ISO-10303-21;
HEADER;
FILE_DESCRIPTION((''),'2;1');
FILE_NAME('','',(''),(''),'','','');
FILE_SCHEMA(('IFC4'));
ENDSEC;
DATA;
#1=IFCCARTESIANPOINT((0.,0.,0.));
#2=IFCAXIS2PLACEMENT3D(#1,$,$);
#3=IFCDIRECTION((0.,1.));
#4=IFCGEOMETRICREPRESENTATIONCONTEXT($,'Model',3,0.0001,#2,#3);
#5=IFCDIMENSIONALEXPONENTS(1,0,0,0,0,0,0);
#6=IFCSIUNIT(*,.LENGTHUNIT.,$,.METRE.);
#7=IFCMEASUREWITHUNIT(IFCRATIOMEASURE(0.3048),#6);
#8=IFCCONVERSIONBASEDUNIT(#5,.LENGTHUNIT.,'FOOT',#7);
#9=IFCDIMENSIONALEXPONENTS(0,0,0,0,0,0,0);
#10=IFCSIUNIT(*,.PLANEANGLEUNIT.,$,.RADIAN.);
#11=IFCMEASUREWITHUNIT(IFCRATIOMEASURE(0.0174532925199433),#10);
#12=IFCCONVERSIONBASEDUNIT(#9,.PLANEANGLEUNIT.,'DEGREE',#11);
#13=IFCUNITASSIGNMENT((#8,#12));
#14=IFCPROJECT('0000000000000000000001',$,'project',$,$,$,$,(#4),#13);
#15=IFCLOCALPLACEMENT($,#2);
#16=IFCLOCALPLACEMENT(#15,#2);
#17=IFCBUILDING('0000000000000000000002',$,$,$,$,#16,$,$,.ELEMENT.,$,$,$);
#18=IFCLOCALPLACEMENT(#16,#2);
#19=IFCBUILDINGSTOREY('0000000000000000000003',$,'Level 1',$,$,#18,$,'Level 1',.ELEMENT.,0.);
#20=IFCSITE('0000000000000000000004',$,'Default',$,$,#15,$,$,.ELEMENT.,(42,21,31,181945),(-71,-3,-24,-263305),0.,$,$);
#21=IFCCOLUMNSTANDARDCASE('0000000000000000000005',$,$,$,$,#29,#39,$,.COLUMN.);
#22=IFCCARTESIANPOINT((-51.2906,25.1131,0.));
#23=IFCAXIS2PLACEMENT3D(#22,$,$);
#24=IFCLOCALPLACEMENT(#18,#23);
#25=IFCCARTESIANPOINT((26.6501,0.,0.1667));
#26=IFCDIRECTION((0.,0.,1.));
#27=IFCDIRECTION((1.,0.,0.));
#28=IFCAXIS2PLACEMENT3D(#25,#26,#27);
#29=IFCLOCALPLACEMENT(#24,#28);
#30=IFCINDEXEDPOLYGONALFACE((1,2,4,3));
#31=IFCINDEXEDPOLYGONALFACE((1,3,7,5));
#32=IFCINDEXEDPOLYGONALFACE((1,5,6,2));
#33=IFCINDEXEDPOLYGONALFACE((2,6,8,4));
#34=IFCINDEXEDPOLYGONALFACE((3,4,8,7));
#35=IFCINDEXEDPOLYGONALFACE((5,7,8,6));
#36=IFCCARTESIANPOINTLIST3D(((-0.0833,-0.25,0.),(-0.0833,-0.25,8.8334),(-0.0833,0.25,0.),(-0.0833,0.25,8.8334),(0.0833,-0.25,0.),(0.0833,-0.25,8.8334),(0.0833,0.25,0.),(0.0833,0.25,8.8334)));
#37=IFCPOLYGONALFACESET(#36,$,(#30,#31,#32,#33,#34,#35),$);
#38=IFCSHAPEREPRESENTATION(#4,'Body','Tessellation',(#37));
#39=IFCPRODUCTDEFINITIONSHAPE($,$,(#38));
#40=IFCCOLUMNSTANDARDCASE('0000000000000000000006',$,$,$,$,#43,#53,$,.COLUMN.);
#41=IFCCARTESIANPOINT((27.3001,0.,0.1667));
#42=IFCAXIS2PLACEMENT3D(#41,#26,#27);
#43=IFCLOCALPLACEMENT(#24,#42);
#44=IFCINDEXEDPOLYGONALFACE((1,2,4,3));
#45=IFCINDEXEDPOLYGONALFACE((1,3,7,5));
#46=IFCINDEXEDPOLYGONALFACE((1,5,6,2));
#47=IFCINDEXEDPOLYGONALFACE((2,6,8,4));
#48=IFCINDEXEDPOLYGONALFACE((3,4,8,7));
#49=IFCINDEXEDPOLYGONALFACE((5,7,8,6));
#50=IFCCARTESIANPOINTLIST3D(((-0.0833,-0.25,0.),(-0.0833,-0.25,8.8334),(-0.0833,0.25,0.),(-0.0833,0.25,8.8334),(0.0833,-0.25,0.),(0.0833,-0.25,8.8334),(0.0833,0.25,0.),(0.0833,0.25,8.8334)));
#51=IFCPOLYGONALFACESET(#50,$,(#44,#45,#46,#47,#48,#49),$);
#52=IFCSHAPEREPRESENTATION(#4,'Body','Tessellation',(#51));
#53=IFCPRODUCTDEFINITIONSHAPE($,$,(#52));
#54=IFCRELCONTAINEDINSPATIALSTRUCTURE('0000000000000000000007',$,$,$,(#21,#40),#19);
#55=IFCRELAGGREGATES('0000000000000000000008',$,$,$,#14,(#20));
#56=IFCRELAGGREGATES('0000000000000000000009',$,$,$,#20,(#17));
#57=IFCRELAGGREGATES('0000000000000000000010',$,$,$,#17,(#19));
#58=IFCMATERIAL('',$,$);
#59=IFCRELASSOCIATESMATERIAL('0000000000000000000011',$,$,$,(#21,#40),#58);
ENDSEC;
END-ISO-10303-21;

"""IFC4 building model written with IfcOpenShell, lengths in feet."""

from ifc_helpers import new_model, entity, si_unit, converted_unit, direction, frame, origin, place, context, project, spatial, rectangle, extrude, material, element, save


model = new_model("IFC4")

# Units and contexts
model_context = context("Model", 3, precision=0.0001, world=origin(), true_north=direction((0.0, 1.0)))
ifc_project = project(units=[converted_unit("LENGTHUNIT", "FOOT", entity("IfcRatioMeasure", 0.3048), si_unit("LENGTHUNIT", "METRE"), dimensions=[1, 0, 0, 0, 0, 0, 0]), converted_unit("PLANEANGLEUNIT", "DEGREE", entity("IfcRatioMeasure", 0.0174532925199433), si_unit("PLANEANGLEUNIT", "RADIAN"), dimensions=[0, 0, 0, 0, 0, 0, 0])], contexts=[model_context])

# Site, building, storey
site_placement = place(None, origin())
site = spatial("IfcSite", under=ifc_project, at=site_placement, Name="Default", CompositionType="ELEMENT", RefLatitude=(42, 21, 31, 181945), RefLongitude=(-71, -3, -24, -263305), RefElevation=0.0)
building_placement = place(site_placement, origin())
building = spatial("IfcBuilding", under=site, at=building_placement, CompositionType="ELEMENT")
storey_placement = place(building_placement, origin())
storey = spatial("IfcBuildingStorey", under=building, at=storey_placement, Name="Level 1", LongName="Level 1", CompositionType="ELEMENT", Elevation=0.0)

# Columns
ifc_material_1 = material(Name="")
placement_1 = place(storey_placement, frame((-51.2906, 25.1131, 0.0)))
for number, where, z_axis, x_axis in (
    (1, (26.6501, 0.0, 0.1667), (0.0, 0.0, 1.0), (1.0, 0.0, 0.0)),
    (2, (27.3001, 0.0, 0.1667), (0.0, 0.0, 1.0), (1.0, 0.0, 0.0)),
):
    element("IfcColumnStandardCase", number, at=place(placement_1, frame(where, z_axis=z_axis, x_axis=x_axis)), inside=storey, material=ifc_material_1, PredefinedType="COLUMN", context=model_context, shape_type="SweptSolid", body=[
        extrude(rectangle(XDim=0.1667, YDim=0.5), origin(), (0.0, 0.0, 1.0), 8.8334),
    ])

save(model, "model.ifc")
